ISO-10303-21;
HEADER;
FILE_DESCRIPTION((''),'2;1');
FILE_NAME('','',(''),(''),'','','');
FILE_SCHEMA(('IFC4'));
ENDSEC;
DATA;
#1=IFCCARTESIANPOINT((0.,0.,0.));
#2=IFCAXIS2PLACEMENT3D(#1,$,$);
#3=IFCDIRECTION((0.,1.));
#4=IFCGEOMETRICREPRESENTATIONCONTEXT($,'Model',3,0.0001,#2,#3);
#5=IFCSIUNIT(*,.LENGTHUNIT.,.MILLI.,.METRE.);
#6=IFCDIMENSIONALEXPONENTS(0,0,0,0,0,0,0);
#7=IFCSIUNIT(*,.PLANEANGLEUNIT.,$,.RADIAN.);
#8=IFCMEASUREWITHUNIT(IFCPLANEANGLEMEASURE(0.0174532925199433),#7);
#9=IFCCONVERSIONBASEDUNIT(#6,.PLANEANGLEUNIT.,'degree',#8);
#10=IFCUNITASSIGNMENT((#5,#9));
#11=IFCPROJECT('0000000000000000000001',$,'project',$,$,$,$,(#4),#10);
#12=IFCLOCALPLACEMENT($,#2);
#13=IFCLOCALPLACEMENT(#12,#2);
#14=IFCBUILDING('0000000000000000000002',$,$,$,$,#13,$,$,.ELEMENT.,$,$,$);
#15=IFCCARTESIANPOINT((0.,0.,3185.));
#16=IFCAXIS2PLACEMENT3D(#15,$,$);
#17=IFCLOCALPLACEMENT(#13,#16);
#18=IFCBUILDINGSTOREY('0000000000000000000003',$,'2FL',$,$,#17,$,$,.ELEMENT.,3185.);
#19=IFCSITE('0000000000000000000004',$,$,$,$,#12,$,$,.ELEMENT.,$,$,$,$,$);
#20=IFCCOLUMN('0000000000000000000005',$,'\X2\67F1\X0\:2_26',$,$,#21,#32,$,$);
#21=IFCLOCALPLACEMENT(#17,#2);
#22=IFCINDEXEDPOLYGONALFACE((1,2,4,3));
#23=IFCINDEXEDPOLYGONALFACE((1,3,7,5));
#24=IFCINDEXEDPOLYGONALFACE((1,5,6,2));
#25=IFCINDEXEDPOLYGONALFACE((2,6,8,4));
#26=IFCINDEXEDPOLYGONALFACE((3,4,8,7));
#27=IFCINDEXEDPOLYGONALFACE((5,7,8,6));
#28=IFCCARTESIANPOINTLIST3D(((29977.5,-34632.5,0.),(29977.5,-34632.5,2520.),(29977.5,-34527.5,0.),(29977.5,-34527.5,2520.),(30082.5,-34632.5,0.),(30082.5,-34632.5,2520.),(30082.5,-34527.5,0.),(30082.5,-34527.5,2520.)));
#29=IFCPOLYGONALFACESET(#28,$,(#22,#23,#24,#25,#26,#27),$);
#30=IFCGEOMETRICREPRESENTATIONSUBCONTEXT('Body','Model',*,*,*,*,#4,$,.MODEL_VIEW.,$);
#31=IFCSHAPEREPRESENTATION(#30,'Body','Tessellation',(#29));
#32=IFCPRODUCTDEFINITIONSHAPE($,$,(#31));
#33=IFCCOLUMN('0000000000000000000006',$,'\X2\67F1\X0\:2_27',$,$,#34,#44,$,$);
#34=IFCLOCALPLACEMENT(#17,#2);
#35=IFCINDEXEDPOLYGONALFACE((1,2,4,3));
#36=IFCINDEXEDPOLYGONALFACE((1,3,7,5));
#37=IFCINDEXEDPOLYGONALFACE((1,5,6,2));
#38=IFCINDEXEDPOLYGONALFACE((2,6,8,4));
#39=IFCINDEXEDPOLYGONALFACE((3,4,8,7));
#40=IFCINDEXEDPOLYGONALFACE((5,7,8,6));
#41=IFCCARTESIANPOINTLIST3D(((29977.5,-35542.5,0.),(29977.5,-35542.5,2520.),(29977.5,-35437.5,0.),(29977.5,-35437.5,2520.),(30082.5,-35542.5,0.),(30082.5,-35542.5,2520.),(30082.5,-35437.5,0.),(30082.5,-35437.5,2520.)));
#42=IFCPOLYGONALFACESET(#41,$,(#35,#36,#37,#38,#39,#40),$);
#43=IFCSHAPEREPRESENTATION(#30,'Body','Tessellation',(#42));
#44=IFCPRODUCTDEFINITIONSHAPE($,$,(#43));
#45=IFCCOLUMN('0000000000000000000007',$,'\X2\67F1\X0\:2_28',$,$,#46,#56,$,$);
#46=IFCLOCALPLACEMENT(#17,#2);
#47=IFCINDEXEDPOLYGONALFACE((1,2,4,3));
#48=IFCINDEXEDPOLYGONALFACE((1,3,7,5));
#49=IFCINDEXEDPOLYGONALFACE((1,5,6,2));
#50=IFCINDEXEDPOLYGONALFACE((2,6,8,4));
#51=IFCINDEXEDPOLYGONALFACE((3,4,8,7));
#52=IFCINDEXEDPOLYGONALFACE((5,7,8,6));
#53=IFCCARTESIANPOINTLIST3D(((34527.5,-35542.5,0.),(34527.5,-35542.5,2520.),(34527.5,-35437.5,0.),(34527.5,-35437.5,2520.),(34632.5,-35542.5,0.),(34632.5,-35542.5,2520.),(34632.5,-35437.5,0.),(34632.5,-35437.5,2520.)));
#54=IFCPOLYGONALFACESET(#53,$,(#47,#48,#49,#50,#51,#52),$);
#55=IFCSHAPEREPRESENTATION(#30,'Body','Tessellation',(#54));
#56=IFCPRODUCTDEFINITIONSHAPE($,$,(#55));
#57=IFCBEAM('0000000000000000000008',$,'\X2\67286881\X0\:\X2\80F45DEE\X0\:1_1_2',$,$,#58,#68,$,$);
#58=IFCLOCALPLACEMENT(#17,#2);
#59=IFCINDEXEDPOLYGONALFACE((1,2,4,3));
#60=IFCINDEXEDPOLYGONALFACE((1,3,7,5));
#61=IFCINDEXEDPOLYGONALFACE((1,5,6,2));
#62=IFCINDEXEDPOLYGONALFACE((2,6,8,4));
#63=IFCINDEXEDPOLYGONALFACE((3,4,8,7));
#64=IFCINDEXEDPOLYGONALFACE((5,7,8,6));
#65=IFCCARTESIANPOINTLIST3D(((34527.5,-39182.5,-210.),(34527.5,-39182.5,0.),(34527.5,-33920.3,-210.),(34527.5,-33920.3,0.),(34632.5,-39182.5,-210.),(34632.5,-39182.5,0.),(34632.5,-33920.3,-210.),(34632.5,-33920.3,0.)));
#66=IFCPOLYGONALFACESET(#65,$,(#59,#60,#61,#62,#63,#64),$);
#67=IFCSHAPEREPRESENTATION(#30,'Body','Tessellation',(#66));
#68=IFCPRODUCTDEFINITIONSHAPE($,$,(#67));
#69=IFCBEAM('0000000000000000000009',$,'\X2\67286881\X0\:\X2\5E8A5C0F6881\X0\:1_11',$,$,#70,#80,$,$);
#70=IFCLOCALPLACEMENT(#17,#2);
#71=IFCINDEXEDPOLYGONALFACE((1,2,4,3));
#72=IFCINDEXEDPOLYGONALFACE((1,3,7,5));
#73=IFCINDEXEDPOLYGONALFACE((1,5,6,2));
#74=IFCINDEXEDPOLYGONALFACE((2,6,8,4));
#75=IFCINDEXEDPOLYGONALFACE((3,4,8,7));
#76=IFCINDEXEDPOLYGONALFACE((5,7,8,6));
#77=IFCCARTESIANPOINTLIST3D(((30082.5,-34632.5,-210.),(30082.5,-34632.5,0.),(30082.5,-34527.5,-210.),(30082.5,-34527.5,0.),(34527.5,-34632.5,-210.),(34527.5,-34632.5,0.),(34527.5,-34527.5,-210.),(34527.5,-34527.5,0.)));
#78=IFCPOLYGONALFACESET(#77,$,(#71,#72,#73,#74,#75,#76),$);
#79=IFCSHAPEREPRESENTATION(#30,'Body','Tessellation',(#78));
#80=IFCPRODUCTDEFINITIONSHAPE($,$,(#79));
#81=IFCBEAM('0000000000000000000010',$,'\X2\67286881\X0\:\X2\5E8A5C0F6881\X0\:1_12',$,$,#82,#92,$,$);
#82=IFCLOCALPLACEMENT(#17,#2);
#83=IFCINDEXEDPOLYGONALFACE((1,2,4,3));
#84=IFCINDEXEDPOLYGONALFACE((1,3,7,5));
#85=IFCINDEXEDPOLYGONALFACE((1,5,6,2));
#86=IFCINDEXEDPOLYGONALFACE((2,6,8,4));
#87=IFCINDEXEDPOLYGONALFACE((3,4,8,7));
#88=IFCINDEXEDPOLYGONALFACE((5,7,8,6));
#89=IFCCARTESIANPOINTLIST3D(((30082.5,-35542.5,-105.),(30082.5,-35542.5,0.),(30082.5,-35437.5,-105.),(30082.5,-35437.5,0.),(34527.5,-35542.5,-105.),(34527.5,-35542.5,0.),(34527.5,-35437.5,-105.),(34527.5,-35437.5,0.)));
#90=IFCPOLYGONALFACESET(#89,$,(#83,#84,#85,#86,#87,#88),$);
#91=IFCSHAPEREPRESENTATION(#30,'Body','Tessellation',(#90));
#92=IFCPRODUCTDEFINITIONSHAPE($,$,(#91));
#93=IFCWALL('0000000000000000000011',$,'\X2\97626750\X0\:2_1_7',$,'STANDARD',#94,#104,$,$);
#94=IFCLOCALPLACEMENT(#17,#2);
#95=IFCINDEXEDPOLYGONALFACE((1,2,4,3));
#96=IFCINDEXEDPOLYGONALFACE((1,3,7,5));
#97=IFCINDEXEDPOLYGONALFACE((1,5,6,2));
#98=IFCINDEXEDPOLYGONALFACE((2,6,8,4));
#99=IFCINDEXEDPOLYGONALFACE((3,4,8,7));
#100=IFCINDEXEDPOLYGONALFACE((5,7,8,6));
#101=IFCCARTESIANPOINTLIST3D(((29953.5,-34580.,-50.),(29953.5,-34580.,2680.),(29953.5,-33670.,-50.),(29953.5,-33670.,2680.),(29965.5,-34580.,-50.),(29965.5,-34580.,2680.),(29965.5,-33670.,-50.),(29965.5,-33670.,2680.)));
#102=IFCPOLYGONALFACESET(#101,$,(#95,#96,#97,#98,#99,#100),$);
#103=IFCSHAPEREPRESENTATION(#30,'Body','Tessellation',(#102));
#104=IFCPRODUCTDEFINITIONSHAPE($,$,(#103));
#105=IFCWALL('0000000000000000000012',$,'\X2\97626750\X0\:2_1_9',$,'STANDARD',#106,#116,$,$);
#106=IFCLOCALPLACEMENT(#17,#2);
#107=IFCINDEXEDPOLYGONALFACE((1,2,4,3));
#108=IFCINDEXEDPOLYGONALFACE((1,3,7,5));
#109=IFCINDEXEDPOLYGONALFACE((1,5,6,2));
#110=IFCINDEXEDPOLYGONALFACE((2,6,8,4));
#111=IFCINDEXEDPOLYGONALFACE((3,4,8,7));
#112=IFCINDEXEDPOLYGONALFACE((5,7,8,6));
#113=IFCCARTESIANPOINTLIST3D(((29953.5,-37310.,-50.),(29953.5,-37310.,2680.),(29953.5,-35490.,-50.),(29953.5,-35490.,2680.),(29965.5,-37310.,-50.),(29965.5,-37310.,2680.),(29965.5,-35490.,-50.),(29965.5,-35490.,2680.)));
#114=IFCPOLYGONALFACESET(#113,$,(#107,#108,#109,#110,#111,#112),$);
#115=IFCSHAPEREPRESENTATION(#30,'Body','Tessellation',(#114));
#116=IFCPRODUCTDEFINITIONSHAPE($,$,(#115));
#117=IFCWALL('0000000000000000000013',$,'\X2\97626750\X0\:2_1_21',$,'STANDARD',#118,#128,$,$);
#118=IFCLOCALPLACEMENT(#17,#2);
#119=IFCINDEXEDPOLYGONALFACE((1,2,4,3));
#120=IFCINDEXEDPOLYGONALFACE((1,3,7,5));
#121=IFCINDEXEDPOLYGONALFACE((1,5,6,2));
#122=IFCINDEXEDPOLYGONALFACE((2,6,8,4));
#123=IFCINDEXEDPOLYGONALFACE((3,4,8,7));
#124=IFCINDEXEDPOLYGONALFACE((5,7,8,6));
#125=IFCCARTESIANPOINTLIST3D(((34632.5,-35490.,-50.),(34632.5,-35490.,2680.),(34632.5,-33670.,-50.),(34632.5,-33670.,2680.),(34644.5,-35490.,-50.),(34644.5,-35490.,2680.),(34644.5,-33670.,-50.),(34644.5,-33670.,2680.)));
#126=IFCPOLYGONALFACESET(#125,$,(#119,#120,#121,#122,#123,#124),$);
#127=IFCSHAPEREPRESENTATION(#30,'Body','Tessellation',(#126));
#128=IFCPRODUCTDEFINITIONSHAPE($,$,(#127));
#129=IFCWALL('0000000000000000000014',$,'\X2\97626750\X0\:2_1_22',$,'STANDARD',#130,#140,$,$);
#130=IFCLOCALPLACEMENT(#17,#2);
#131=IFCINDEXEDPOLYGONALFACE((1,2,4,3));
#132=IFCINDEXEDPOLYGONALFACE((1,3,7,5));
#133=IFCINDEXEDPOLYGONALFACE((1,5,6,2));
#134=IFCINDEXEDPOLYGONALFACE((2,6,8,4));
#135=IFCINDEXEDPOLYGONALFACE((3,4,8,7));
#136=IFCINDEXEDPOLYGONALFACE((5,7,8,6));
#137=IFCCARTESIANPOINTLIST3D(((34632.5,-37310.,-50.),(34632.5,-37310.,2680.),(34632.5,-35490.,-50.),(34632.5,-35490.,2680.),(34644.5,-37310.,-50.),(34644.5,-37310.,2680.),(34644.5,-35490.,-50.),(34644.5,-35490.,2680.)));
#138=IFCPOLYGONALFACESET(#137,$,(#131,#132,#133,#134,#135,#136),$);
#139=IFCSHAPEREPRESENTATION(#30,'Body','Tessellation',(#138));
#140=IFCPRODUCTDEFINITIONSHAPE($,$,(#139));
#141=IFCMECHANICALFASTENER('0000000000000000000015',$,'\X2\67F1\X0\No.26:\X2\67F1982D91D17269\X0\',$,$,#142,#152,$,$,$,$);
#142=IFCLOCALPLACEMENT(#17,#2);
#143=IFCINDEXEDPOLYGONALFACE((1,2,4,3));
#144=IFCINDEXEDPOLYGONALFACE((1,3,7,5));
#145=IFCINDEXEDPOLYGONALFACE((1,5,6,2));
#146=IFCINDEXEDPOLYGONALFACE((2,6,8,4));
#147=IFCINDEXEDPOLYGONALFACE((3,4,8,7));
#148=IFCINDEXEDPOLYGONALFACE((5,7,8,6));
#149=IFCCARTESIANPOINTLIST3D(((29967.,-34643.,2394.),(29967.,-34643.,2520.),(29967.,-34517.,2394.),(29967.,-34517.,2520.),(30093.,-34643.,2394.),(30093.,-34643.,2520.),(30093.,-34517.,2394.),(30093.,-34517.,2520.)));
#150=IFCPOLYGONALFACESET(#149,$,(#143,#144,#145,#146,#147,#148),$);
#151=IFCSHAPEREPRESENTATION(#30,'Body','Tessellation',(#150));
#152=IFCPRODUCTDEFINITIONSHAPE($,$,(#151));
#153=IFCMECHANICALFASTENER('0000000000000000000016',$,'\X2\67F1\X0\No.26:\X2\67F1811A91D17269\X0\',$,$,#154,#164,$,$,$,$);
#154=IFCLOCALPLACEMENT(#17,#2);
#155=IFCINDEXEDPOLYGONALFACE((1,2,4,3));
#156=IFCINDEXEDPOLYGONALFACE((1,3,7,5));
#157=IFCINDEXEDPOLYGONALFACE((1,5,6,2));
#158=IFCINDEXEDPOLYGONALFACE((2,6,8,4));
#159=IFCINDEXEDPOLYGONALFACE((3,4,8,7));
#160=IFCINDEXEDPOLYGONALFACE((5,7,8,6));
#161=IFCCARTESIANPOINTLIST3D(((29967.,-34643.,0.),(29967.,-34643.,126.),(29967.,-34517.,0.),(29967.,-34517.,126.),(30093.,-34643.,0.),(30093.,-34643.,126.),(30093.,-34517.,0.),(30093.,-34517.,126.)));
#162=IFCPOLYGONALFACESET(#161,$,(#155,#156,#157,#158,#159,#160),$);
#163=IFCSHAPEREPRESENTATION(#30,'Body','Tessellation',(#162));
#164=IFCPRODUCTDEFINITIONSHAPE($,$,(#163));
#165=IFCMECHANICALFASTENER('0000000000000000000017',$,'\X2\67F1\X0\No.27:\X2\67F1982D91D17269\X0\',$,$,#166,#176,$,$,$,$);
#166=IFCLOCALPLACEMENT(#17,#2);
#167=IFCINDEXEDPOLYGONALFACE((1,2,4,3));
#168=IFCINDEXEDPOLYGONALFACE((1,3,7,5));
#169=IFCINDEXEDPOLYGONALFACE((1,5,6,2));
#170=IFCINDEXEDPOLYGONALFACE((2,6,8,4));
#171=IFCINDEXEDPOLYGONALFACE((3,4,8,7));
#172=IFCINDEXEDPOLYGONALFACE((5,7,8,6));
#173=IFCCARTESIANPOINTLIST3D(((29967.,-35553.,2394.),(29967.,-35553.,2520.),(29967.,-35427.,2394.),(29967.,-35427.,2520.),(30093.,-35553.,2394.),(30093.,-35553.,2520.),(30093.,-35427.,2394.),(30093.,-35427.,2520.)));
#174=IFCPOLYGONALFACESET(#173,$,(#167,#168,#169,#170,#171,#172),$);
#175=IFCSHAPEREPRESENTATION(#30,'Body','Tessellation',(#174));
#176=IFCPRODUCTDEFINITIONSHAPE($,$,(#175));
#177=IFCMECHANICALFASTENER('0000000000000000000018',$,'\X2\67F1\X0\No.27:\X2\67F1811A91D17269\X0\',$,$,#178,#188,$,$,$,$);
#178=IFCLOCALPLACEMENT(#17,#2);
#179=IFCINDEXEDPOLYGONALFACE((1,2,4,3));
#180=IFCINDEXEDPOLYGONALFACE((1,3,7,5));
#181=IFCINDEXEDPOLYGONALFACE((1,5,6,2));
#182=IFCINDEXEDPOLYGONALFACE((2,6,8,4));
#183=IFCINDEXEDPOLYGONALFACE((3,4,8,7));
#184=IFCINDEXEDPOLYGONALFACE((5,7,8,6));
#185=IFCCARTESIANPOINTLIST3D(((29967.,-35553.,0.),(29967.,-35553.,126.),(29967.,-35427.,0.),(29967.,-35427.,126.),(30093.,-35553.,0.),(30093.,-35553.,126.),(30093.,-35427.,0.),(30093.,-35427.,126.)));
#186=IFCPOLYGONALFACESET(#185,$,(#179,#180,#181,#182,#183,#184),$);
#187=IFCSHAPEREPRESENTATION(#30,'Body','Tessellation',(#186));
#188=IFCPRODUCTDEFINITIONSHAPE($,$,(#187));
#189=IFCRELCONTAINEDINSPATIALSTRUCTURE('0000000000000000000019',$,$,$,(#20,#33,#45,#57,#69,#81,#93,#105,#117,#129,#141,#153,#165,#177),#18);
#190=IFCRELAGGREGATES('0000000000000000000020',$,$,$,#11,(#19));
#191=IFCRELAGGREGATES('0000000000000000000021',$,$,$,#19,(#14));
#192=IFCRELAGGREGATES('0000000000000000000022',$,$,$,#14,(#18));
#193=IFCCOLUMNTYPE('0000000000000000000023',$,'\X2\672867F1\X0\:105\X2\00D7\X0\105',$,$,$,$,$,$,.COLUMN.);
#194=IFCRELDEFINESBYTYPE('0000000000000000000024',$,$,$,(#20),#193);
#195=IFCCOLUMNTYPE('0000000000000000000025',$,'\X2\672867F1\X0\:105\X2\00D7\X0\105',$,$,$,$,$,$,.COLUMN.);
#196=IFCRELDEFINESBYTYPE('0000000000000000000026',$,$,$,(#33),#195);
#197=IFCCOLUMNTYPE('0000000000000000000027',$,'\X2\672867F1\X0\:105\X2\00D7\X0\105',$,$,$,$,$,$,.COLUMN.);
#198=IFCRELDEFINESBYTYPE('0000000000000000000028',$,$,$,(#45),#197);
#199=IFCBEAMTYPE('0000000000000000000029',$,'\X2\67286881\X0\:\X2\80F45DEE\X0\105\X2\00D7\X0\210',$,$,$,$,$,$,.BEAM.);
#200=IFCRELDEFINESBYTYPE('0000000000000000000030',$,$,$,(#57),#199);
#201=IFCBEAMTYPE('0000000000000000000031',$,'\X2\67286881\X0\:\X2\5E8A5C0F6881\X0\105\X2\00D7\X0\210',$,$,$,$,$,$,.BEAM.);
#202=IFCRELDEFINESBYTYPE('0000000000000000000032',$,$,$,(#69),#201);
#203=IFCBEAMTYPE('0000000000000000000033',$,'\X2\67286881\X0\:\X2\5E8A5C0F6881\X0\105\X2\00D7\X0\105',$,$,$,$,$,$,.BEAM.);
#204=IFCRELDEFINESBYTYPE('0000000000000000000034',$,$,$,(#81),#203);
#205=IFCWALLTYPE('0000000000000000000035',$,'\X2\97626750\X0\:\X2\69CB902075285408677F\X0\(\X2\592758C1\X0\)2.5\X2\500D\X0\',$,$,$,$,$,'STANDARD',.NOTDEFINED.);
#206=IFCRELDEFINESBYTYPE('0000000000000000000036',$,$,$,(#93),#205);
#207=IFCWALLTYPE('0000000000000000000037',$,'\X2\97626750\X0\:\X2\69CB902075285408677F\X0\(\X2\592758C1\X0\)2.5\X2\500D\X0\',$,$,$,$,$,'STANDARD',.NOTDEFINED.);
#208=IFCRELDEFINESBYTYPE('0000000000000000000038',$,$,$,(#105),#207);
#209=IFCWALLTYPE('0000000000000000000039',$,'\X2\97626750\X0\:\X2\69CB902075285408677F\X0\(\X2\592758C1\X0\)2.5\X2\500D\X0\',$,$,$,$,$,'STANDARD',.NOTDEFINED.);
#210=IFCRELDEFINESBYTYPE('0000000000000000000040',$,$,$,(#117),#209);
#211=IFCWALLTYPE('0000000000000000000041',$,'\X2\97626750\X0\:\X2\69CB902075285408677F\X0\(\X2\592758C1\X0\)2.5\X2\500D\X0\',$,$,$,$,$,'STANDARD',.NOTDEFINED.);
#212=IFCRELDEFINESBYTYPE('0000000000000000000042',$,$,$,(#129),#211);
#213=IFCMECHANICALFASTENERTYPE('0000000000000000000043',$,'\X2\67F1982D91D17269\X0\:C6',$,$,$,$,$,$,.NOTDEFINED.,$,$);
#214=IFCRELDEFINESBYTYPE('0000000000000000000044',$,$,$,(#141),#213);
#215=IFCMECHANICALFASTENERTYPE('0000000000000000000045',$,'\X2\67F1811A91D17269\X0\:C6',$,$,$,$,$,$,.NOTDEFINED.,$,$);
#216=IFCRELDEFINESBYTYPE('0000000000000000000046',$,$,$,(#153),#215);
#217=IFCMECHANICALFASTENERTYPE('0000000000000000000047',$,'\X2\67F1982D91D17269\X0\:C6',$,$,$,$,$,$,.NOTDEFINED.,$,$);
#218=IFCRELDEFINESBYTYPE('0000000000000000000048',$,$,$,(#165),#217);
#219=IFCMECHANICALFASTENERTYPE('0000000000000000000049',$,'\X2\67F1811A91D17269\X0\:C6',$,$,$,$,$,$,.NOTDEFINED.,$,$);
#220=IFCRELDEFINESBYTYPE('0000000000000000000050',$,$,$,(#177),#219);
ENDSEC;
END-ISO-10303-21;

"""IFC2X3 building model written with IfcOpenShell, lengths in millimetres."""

from ifc_helpers import new_model, entity, si_unit, converted_unit, direction, frame, origin, origin_with_axes, origin_2d, place, context, subcontext, project, spatial, polyline, rectangle, outline, extrude, type_object, element, save


model = new_model("IFC2X3")

# Units and contexts
model_context = context("Model", 3, precision=0.0001, world=origin(), true_north=direction((0.0, 1.0)))
body_context = subcontext(model_context, "Body", "Model", "MODEL_VIEW")
ifc_project = project(units=[si_unit("LENGTHUNIT", "METRE", prefix="MILLI"), converted_unit("PLANEANGLEUNIT", "degree", entity("IfcPlaneAngleMeasure", 0.0174532925199433), si_unit("PLANEANGLEUNIT", "RADIAN"), dimensions=[0, 0, 0, 0, 0, 0, 0])], contexts=[model_context])

# Site, building, storey
site_placement = place(None, origin())
site = spatial("IfcSite", under=ifc_project, at=site_placement, CompositionType="ELEMENT")
building_placement = place(site_placement, origin())
building = spatial("IfcBuilding", under=site, at=building_placement, CompositionType="ELEMENT")
storey_placement = place(building_placement, frame((0.0, 0.0, 3185.0)))
storey = spatial("IfcBuildingStorey", under=building, at=storey_placement, Name="2FL", CompositionType="ELEMENT", Elevation=3185.0)

# Columns
column_type_1 = type_object("IfcColumnType", Name="木柱:105×105", PredefinedType="COLUMN")
column_1_placement = place(storey_placement, frame((30030.0, -34580.0, 0.0)))
element("IfcColumn", 1, at=column_1_placement, inside=storey, type_object=column_type_1, Name="柱:2_26", context=body_context, shape_type="SweptSolid", body=[
    extrude(rectangle(XDim=105.0, YDim=105.0, at=origin_2d()), origin_with_axes(), (0.0, 0.0, 1.0), 2520.0),
])
column_type_2 = type_object("IfcColumnType", Name="木柱:105×105", PredefinedType="COLUMN")
column_2_placement = place(storey_placement, frame((30030.0, -35490.0, 0.0)))
element("IfcColumn", 2, at=column_2_placement, inside=storey, type_object=column_type_2, Name="柱:2_27", context=body_context, shape_type="SweptSolid", body=[
    extrude(rectangle(XDim=105.0, YDim=105.0, at=origin_2d()), origin_with_axes(), (0.0, 0.0, 1.0), 2520.0),
])
column_type_3 = type_object("IfcColumnType", Name="木柱:105×105", PredefinedType="COLUMN")
column_3_placement = place(storey_placement, frame((34580.0, -35490.0, 0.0)))
element("IfcColumn", 3, at=column_3_placement, inside=storey, type_object=column_type_3, Name="柱:2_28", context=body_context, shape_type="SweptSolid", body=[
    extrude(rectangle(XDim=105.0, YDim=105.0, at=origin_2d()), origin_with_axes(), (0.0, 0.0, 1.0), 2520.0),
])

# Beams
beam_type_1 = type_object("IfcBeamType", Name="木梁:胴差105×210", PredefinedType="BEAM")
beam_1_placement = place(storey_placement, frame((34580.0, -33920.3, -105.0), z_axis=(0.0, -1.0, 0.0), x_axis=(1.0, 0.0, 0.0)))
element("IfcBeam", 4, at=beam_1_placement, inside=storey, type_object=beam_type_1, Name="木梁:胴差:1_1_2", context=body_context, shape_type="SweptSolid", body=[
    extrude(rectangle(XDim=105.0, YDim=210.0, at=origin_2d()), origin_with_axes(), (0.0, 0.0, 1.0), 5262.2),
])
beam_type_2 = type_object("IfcBeamType", Name="木梁:床小梁105×210", PredefinedType="BEAM")
beam_2_placement = place(storey_placement, frame((30082.5, -34580.0, -105.0), z_axis=(1.0, 0.0, 0.0), x_axis=(0.0, 1.0, 0.0)))
element("IfcBeam", 5, at=beam_2_placement, inside=storey, type_object=beam_type_2, Name="木梁:床小梁:1_11", context=body_context, shape_type="SweptSolid", body=[
    extrude(rectangle(XDim=105.0, YDim=210.0, at=origin_2d()), origin_with_axes(), (0.0, 0.0, 1.0), 4445.0),
])
beam_type_3 = type_object("IfcBeamType", Name="木梁:床小梁105×105", PredefinedType="BEAM")
beam_3_placement = place(storey_placement, frame((30082.5, -35490.0, -52.5), z_axis=(1.0, 0.0, 0.0), x_axis=(0.0, 1.0, 0.0)))
element("IfcBeam", 6, at=beam_3_placement, inside=storey, type_object=beam_type_3, Name="木梁:床小梁:1_12", context=body_context, shape_type="SweptSolid", body=[
    extrude(rectangle(XDim=105.0, YDim=105.0, at=origin_2d()), origin_with_axes(), (0.0, 0.0, 1.0), 4445.0),
])

# Walls
wall_type_1 = type_object("IfcWallType", Name="面材:構造用合板(大壁)2.5倍", ElementType="STANDARD", PredefinedType="NOTDEFINED")
wall_1_placement = place(storey_placement, frame((29965.5, -34125.0, -50.0), z_axis=(-1.0, 0.0, 0.0), x_axis=(0.0, -1.0, 0.0)))
element("IfcWall", 7, at=wall_1_placement, inside=storey, type_object=wall_type_1, Name="面材:2_1_7", ObjectType="STANDARD", context=body_context, shape_type="SweptSolid", body=[
    extrude(outline(polyline([(455.0, 0.0, 0.0), (-455.0, 0.0, 0.0), (-455.0, 2730.0, 0.0), (455.0, 2730.0, 0.0), (455.0, 0.0, 0.0)])), origin_with_axes(), (0.0, 0.0, 1.0), 12.0),
])
wall_type_2 = type_object("IfcWallType", Name="面材:構造用合板(大壁)2.5倍", ElementType="STANDARD", PredefinedType="NOTDEFINED")
wall_2_placement = place(storey_placement, frame((29965.5, -36400.0, -50.0), z_axis=(-1.0, 0.0, 0.0), x_axis=(0.0, -1.0, 0.0)))
element("IfcWall", 8, at=wall_2_placement, inside=storey, type_object=wall_type_2, Name="面材:2_1_9", ObjectType="STANDARD", context=body_context, shape_type="SweptSolid", body=[
    extrude(outline(polyline([(910.0, 0.0, 0.0), (-910.0, 0.0, 0.0), (-910.0, 2730.0, 0.0), (910.0, 2730.0, 0.0), (910.0, 0.0, 0.0)])), origin_with_axes(), (0.0, 0.0, 1.0), 12.0),
])
wall_type_3 = type_object("IfcWallType", Name="面材:構造用合板(大壁)2.5倍", ElementType="STANDARD", PredefinedType="NOTDEFINED")
wall_3_placement = place(storey_placement, frame((34644.5, -34580.0, -50.0), z_axis=(-1.0, 0.0, 0.0), x_axis=(0.0, -1.0, 0.0)))
element("IfcWall", 9, at=wall_3_placement, inside=storey, type_object=wall_type_3, Name="面材:2_1_21", ObjectType="STANDARD", context=body_context, shape_type="SweptSolid", body=[
    extrude(outline(polyline([(910.0, 0.0, 0.0), (-910.0, 0.0, 0.0), (-910.0, 2730.0, 0.0), (910.0, 2730.0, 0.0), (910.0, 0.0, 0.0)])), origin_with_axes(), (0.0, 0.0, 1.0), 12.0),
])
wall_type_4 = type_object("IfcWallType", Name="面材:構造用合板(大壁)2.5倍", ElementType="STANDARD", PredefinedType="NOTDEFINED")
wall_4_placement = place(storey_placement, frame((34644.5, -36400.0, -50.0), z_axis=(-1.0, 0.0, 0.0), x_axis=(0.0, -1.0, 0.0)))
element("IfcWall", 10, at=wall_4_placement, inside=storey, type_object=wall_type_4, Name="面材:2_1_22", ObjectType="STANDARD", context=body_context, shape_type="SweptSolid", body=[
    extrude(outline(polyline([(910.0, 0.0, 0.0), (-910.0, 0.0, 0.0), (-910.0, 2730.0, 0.0), (910.0, 2730.0, 0.0), (910.0, 0.0, 0.0)])), origin_with_axes(), (0.0, 0.0, 1.0), 12.0),
])

# Mechanical fasteners
mechanical_fastener_type_1 = type_object("IfcMechanicalFastenerType", Name="柱頭金物:C6")
mechanical_fastener_1_placement = place(storey_placement, frame((30030.0, -34580.0, 2394.0)))
element("IfcMechanicalFastener", 11, at=mechanical_fastener_1_placement, inside=storey, type_object=mechanical_fastener_type_1, Name="柱No.26:柱頭金物", context=body_context, shape_type="SweptSolid", body=[
    extrude(rectangle(XDim=126.0, YDim=126.0, at=origin_2d()), origin_with_axes(), (0.0, 0.0, 1.0), 126.0),
])
mechanical_fastener_type_2 = type_object("IfcMechanicalFastenerType", Name="柱脚金物:C6")
mechanical_fastener_2_placement = place(storey_placement, frame((30030.0, -34580.0, 0.0)))
element("IfcMechanicalFastener", 12, at=mechanical_fastener_2_placement, inside=storey, type_object=mechanical_fastener_type_2, Name="柱No.26:柱脚金物", context=body_context, shape_type="SweptSolid", body=[
    extrude(rectangle(XDim=126.0, YDim=126.0, at=origin_2d()), origin_with_axes(), (0.0, 0.0, 1.0), 126.0),
])
mechanical_fastener_type_3 = type_object("IfcMechanicalFastenerType", Name="柱頭金物:C6")
mechanical_fastener_3_placement = place(storey_placement, frame((30030.0, -35490.0, 2394.0)))
element("IfcMechanicalFastener", 13, at=mechanical_fastener_3_placement, inside=storey, type_object=mechanical_fastener_type_3, Name="柱No.27:柱頭金物", context=body_context, shape_type="SweptSolid", body=[
    extrude(rectangle(XDim=126.0, YDim=126.0, at=origin_2d()), origin_with_axes(), (0.0, 0.0, 1.0), 126.0),
])
mechanical_fastener_type_4 = type_object("IfcMechanicalFastenerType", Name="柱脚金物:C6")
mechanical_fastener_4_placement = place(storey_placement, frame((30030.0, -35490.0, 0.0)))
element("IfcMechanicalFastener", 14, at=mechanical_fastener_4_placement, inside=storey, type_object=mechanical_fastener_type_4, Name="柱No.27:柱脚金物", context=body_context, shape_type="SweptSolid", body=[
    extrude(rectangle(XDim=126.0, YDim=126.0, at=origin_2d()), origin_with_axes(), (0.0, 0.0, 1.0), 126.0),
])

save(model, "model.ifc")
